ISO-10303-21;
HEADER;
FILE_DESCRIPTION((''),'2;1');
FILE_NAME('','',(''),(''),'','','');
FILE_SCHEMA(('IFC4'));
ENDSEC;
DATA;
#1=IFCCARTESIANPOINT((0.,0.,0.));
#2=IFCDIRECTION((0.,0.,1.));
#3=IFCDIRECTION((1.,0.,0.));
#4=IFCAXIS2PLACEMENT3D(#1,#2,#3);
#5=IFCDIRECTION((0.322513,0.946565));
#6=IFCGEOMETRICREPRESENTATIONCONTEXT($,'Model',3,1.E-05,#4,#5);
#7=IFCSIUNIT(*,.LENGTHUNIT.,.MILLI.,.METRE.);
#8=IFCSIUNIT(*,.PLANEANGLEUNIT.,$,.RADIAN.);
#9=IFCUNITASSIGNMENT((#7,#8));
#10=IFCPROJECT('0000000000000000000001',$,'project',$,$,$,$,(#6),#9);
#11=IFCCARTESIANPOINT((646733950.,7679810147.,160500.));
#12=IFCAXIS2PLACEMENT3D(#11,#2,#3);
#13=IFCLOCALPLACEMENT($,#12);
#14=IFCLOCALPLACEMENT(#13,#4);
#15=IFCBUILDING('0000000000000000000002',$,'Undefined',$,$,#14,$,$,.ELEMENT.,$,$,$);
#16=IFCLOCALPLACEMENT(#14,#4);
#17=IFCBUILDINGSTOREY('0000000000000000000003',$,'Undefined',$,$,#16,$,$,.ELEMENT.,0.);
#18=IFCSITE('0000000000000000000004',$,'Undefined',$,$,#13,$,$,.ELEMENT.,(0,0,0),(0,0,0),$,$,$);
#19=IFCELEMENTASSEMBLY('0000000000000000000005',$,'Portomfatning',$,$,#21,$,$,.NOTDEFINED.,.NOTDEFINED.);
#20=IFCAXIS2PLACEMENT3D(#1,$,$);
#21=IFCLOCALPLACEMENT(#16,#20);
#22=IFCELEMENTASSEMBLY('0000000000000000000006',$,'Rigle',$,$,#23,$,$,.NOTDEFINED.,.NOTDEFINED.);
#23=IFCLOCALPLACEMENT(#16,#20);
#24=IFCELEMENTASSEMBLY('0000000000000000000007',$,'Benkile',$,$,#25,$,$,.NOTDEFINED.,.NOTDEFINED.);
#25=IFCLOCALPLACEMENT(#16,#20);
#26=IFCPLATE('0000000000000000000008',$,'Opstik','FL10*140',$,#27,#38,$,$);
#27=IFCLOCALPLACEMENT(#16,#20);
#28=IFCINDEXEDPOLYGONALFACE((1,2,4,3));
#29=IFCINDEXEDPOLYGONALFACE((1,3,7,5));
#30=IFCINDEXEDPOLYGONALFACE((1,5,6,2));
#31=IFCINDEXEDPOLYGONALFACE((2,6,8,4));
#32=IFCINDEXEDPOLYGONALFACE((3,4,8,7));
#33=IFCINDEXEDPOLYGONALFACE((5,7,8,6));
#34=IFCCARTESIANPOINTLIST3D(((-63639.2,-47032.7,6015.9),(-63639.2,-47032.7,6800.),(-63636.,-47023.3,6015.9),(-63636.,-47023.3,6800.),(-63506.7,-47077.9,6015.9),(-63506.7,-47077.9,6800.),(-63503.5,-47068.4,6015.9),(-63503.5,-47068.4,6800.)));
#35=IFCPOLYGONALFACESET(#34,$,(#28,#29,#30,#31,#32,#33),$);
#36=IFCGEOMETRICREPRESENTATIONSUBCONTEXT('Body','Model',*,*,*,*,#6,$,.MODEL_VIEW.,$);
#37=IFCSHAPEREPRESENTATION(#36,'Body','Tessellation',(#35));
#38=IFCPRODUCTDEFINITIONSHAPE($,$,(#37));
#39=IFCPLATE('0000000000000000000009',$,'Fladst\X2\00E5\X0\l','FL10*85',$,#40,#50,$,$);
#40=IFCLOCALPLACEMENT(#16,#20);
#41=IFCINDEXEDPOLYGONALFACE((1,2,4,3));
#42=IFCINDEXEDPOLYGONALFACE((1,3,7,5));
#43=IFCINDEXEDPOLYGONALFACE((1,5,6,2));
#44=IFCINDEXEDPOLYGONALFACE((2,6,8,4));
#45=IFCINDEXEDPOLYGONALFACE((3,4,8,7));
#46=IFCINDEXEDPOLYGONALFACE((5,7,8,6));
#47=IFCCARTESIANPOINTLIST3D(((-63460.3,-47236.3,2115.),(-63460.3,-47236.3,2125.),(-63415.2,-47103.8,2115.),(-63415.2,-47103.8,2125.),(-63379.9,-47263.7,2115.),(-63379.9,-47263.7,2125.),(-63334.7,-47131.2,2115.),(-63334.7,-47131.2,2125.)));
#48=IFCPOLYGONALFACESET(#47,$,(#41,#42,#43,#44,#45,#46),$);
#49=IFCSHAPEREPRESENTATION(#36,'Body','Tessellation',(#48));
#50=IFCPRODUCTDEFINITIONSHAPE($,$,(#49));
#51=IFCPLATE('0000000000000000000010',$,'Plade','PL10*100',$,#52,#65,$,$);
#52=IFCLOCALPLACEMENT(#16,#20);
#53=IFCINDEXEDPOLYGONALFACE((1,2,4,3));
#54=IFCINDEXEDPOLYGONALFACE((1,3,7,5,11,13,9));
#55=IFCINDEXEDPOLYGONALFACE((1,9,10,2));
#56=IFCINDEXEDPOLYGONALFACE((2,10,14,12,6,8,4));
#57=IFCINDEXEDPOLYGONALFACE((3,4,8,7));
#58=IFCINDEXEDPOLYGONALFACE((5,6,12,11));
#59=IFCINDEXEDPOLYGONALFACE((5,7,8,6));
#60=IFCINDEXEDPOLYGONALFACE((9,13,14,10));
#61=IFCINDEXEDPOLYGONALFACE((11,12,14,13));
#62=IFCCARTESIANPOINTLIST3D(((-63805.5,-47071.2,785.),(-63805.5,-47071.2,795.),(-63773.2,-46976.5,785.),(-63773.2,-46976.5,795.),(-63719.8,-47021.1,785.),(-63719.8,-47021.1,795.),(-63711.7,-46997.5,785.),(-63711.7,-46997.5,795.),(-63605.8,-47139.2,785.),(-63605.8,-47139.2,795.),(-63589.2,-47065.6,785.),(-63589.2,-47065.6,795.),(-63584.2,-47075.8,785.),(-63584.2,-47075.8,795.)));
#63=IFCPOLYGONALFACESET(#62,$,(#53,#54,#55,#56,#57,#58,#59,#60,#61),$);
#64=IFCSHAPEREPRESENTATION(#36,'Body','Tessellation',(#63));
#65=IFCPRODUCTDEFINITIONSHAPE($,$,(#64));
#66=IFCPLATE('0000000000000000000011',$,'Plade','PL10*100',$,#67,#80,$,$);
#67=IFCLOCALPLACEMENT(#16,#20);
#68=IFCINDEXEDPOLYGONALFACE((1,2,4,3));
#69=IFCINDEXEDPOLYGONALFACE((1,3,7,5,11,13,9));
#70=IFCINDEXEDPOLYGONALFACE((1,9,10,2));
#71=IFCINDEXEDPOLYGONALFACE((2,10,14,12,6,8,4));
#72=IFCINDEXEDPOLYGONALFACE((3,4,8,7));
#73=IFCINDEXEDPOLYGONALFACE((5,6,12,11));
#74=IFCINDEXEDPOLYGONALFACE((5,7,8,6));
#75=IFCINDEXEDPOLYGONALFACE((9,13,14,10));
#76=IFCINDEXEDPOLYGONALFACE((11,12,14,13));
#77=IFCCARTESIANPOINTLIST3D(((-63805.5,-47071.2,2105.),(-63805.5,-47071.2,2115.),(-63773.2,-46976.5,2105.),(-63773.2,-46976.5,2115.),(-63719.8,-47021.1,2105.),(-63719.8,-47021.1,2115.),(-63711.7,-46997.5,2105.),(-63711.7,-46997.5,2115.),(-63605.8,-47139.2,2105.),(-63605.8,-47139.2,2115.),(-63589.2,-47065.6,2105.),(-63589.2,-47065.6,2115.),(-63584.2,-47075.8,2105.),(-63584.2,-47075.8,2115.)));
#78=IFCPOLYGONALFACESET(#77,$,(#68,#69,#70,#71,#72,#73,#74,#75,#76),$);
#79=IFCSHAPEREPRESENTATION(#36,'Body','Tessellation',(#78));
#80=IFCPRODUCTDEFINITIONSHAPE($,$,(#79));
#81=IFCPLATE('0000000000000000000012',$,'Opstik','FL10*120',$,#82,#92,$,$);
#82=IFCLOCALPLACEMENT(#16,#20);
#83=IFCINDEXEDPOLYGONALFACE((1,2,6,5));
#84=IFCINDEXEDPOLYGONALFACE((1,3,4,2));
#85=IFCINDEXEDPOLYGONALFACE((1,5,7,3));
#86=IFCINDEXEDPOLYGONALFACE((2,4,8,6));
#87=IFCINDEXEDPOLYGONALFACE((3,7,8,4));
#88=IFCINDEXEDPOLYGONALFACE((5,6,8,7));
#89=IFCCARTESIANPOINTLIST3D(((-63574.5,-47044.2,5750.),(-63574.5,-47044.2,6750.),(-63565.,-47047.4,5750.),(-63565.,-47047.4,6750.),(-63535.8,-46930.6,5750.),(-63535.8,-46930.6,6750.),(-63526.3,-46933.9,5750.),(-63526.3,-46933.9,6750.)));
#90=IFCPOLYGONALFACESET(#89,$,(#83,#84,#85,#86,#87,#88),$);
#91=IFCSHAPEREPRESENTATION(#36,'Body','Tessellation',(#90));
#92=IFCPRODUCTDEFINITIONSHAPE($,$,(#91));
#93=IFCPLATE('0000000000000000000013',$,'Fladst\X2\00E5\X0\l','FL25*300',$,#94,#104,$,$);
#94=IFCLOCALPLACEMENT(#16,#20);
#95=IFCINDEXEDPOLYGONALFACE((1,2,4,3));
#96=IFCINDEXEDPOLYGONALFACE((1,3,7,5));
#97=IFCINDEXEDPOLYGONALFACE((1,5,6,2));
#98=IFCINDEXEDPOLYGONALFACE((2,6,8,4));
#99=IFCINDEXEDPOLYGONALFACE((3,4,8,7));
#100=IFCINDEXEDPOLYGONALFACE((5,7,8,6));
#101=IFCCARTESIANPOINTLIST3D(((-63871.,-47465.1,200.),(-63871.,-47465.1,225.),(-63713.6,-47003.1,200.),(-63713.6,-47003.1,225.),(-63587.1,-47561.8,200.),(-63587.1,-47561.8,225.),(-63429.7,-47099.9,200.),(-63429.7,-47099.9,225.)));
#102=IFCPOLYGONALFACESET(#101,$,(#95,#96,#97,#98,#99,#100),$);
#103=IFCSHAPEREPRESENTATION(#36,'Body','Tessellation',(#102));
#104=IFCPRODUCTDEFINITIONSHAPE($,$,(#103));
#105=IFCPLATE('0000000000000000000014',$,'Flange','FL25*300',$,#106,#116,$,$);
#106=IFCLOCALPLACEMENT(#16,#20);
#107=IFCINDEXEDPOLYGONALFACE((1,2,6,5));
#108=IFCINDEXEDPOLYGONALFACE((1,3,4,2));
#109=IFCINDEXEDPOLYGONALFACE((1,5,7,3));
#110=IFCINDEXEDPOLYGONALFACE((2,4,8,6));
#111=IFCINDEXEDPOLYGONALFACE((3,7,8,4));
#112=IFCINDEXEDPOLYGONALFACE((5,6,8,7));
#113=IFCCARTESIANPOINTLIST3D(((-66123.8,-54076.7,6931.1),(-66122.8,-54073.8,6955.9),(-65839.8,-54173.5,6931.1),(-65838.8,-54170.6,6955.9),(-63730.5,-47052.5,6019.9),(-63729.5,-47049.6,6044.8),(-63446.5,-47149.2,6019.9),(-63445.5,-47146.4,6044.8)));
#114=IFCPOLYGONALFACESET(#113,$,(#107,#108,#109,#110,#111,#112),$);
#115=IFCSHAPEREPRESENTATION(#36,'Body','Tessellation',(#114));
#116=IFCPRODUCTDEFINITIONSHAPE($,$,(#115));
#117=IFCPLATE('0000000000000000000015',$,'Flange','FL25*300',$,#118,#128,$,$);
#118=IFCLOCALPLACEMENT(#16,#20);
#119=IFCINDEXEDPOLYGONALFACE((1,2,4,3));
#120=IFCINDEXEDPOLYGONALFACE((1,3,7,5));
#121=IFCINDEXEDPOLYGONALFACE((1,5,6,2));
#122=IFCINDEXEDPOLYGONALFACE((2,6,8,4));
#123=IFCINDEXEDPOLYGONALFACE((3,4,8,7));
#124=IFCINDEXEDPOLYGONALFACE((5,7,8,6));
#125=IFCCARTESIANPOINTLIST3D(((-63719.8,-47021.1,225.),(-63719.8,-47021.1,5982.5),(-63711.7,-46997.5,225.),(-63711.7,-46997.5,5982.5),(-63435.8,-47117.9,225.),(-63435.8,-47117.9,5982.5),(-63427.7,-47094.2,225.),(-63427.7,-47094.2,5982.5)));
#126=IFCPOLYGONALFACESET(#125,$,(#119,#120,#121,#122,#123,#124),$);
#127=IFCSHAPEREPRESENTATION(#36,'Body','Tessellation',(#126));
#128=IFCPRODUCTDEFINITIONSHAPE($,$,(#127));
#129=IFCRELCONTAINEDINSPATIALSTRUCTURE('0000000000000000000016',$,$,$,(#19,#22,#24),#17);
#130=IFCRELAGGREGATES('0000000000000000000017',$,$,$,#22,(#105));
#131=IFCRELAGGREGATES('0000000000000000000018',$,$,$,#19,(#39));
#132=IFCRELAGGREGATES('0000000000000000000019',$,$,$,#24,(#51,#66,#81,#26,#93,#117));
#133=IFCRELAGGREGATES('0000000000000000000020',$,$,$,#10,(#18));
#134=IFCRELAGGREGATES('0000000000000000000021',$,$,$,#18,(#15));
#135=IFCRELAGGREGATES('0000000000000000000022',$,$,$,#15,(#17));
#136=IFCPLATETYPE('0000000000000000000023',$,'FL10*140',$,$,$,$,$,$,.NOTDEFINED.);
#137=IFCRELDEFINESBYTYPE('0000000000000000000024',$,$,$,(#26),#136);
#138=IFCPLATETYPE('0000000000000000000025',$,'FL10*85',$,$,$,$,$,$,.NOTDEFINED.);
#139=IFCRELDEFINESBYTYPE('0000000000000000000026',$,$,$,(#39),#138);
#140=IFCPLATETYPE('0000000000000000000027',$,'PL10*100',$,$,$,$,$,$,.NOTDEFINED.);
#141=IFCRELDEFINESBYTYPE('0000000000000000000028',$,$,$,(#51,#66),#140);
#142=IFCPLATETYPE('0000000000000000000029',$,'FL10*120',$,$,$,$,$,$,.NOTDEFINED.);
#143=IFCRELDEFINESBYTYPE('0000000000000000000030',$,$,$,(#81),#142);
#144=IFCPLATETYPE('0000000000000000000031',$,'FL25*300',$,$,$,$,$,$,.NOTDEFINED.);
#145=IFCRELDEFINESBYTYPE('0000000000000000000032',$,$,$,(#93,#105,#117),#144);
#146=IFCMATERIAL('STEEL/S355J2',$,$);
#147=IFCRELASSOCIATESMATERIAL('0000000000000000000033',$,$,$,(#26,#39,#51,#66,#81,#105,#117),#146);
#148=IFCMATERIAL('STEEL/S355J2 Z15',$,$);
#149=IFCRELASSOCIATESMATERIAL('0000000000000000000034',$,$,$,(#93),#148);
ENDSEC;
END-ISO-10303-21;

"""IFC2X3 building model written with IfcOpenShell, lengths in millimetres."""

from ifc_helpers import new_model, si_unit, direction, frame, origin_with_axes, place, context, subcontext, project, spatial, polyline, outline, extrude, boolean, clip, halfspace, material, type_object, element, aggregate, save


model = new_model("IFC2X3")

# Units and contexts
model_context = context("Model", 3, precision=1e-05, world=origin_with_axes(), true_north=direction((0.322513, 0.946565)))
body_context = subcontext(model_context, "Body", "Model", "MODEL_VIEW")
ifc_project = project(units=[si_unit("LENGTHUNIT", "METRE", prefix="MILLI"), si_unit("PLANEANGLEUNIT", "RADIAN")], contexts=[model_context])

# Site, building, storey
site_placement = place(None, frame((646733950.0, 7679810147.0, 160500.0), z_axis=(0.0, 0.0, 1.0), x_axis=(1.0, 0.0, 0.0)))
site = spatial("IfcSite", under=ifc_project, at=site_placement, Name="Undefined", CompositionType="ELEMENT", RefLatitude=(0, 0, 0), RefLongitude=(0, 0, 0))
building_placement = place(site_placement, origin_with_axes())
building = spatial("IfcBuilding", under=site, at=building_placement, Name="Undefined", CompositionType="ELEMENT")
storey_placement = place(building_placement, origin_with_axes())
storey = spatial("IfcBuildingStorey", under=building, at=storey_placement, Name="Undefined", CompositionType="ELEMENT", Elevation=0.0)

# Element assembly
assembly_1_placement = place(storey_placement, origin_with_axes())
assembly_1 = element("IfcElementAssembly", 1, at=assembly_1_placement, inside=storey, Name="Portomfatning", AssemblyPlace="NOTDEFINED", PredefinedType="NOTDEFINED")
ifc_material_1 = material(Name="STEEL/S355J2")

# Element assembly
assembly_2_placement = place(storey_placement, origin_with_axes())
assembly_2 = element("IfcElementAssembly", 2, at=assembly_2_placement, inside=storey, Name="Rigle", AssemblyPlace="NOTDEFINED", PredefinedType="NOTDEFINED")

# Element assembly
assembly_3_placement = place(storey_placement, origin_with_axes())
assembly_3 = element("IfcElementAssembly", 3, at=assembly_3_placement, inside=storey, Name="Benkile", AssemblyPlace="NOTDEFINED", PredefinedType="NOTDEFINED")

# Plates
plate_type_1 = type_object("IfcPlateType", Name="FL10*140", PredefinedType="NOTDEFINED")
plate_1_placement = place(assembly_3_placement, frame((-63637.6, -47028.0, 6015.9), z_axis=(0.322513, 0.946565, 0.0), x_axis=(0.0, 0.0, 1.0)))
plate_1 = element("IfcPlate", 4, at=plate_1_placement, type_object=plate_type_1, material=ifc_material_1, Name="Opstik", Description="FL10*140", context=body_context, shape_type="SweptSolid", body=[
    extrude(outline(polyline([(0.0, 0.0), (784.1, 0.0), (784.1, 0.0), (784.1, 140.0), (784.1, 140.0), (0.0, 140.0), (0.0, 0.0)])), frame((0.0, 0.0, -5.0), z_axis=(0.0, 0.0, 1.0), x_axis=(1.0, 0.0, 0.0)), (0.0, 0.0, 1.0), 10.0),
])
plate_type_2 = type_object("IfcPlateType", Name="FL10*85", PredefinedType="NOTDEFINED")
plate_2_placement = place(assembly_1_placement, frame((-63357.3, -47197.5, 2120.0), z_axis=(0.0, 0.0, 1.0), x_axis=(-0.946565, 0.322513, 0.0)))
plate_2 = element("IfcPlate", 5, at=plate_2_placement, type_object=plate_type_2, material=ifc_material_1, Name="Fladstål", Description="FL10*85", context=body_context, shape_type="SweptSolid", body=[
    extrude(outline(polyline([(0.0, -70.0), (0.0, 70.0), (85.0, 70.0), (85.0, -70.0), (0.0, -70.0)])), frame((0.0, 0.0, -5.0), z_axis=(0.0, 0.0, 1.0), x_axis=(1.0, 0.0, 0.0)), (0.0, 0.0, 1.0), 10.0),
])
plate_type_3 = type_object("IfcPlateType", Name="PL10*100", PredefinedType="NOTDEFINED")
plate_3_placement = place(assembly_3_placement, frame((-63573.5, -47044.5, 790.0), z_axis=(0.0, 0.0, 1.0), x_axis=(-0.946565, 0.322513, 0.0)))
plate_3 = element("IfcPlate", 6, at=plate_3_placement, type_object=plate_type_3, material=ifc_material_1, Name="Plade", Description="PL10*100", context=body_context, shape_type="CSG", body=[
    boolean("DIFFERENCE", extrude(outline(polyline([(0.0, 25.0), (146.0, 25.0), (146.0, 0.0), (211.0, 0.0), (211.0, 100.0), (0.0, 100.0), (0.0, 25.0)])), frame((0.0, 0.0, -5.0), z_axis=(0.0, 0.0, 1.0), x_axis=(1.0, 0.0, 0.0)), (0.0, 0.0, 1.0), 10.0), extrude(outline(polyline([(0.0, 0.0), (8.0, 0.0), (0.0, 8.0), (0.0, 0.0)])), frame((0.0, 25.0, -7.5), z_axis=(0.0, 0.0, 1.0), x_axis=(1.0, 0.0, 0.0)), (0.0, 0.0, 1.0), 15.0)),
])
plate_4_placement = place(assembly_3_placement, frame((-63573.5, -47044.5, 2110.0), z_axis=(0.0, 0.0, 1.0), x_axis=(-0.946565, 0.322513, 0.0)))
plate_4 = element("IfcPlate", 7, at=plate_4_placement, type_object=plate_type_3, material=ifc_material_1, Name="Plade", Description="PL10*100", context=body_context, shape_type="CSG", body=[
    boolean("DIFFERENCE", extrude(outline(polyline([(0.0, 25.0), (146.0, 25.0), (146.0, 0.0), (211.0, 0.0), (211.0, 100.0), (0.0, 100.0), (0.0, 25.0)])), frame((0.0, 0.0, -5.0), z_axis=(0.0, 0.0, 1.0), x_axis=(1.0, 0.0, 0.0)), (0.0, 0.0, 1.0), 10.0), extrude(outline(polyline([(0.0, 0.0), (8.0, 0.0), (0.0, 8.0), (0.0, 0.0)])), frame((0.0, 25.0, -7.5), z_axis=(0.0, 0.0, 1.0), x_axis=(1.0, 0.0, 0.0)), (0.0, 0.0, 1.0), 15.0)),
])
plate_type_4 = type_object("IfcPlateType", Name="FL10*120", PredefinedType="NOTDEFINED")
plate_5_placement = place(assembly_3_placement, frame((-63569.7, -47045.8, 5750.0), z_axis=(-0.946565, 0.322513, 0.0), x_axis=(0.0, 0.0, 1.0)))
plate_5 = element("IfcPlate", 8, at=plate_5_placement, type_object=plate_type_4, material=ifc_material_1, Name="Opstik", Description="FL10*120", context=body_context, shape_type="SweptSolid", body=[
    extrude(outline(polyline([(0.0, 0.0), (1000.0, 0.0), (1000.0, 120.0), (1000.0, 120.0), (0.0, 120.0), (0.0, 120.0), (0.0, 0.0)])), frame((0.0, 0.0, -5.0), z_axis=(0.0, 0.0, 1.0), x_axis=(1.0, 0.0, 0.0)), (0.0, 0.0, 1.0), 10.0),
])
ifc_material_2 = material(Name="STEEL/S355J2 Z15")
plate_type_5 = type_object("IfcPlateType", Name="FL25*300", PredefinedType="NOTDEFINED")
plate_6_placement = place(assembly_3_placement, frame((-63571.7, -47051.5, 212.5), z_axis=(0.0, 0.0, -1.0), x_axis=(-0.322513, -0.946565, 0.0)))
plate_6 = element("IfcPlate", 9, at=plate_6_placement, type_object=plate_type_5, material=ifc_material_2, Name="Fladstål", Description="FL25*300", context=body_context, shape_type="SweptSolid", body=[
    extrude(outline(polyline([(0.0, -150.0), (0.0, 150.0), (488.0, 150.0), (488.0, -150.0), (0.0, -150.0)])), frame((0.0, 0.0, -12.5), z_axis=(0.0, 0.0, 1.0), x_axis=(1.0, 0.0, 0.0)), (0.0, 0.0, 1.0), 25.0),
])
plate_7_placement = place(assembly_2_placement, frame((-63588.0, -47099.4, 6032.4), z_axis=(-0.039304, -0.115357, -0.992546), x_axis=(-0.320109, -0.93951, 0.121869)))
plate_7 = element("IfcPlate", 10, at=plate_7_placement, type_object=plate_type_5, material=ifc_material_1, Name="Flange", Description="FL25*300", context=body_context, shape_type="Clipping", body=[
    clip(extrude(outline(polyline([(0.0, -150.0), (0.0, 150.0), (7476.5, 150.0), (7476.5, -150.0), (0.0, -150.0)])), frame((0.0, 0.0, -12.5), z_axis=(0.0, 0.0, 1.0), x_axis=(1.0, 0.0, 0.0)), (0.0, 0.0, 1.0), 25.0), halfspace(frame((7476.5, 0.0, 287.5), z_axis=(1.0, 0.0, 0.0), x_axis=(0.0, 1.0, 0.0)), False)),
])
aggregate(assembly_2, [plate_7])
plate_8_placement = place(assembly_3_placement, frame((-63573.8, -47057.7, 200.0), z_axis=(-0.322513, -0.946565, 0.0), x_axis=(0.0, 0.0, 1.0)))
plate_8 = element("IfcPlate", 11, at=plate_8_placement, type_object=plate_type_5, material=ifc_material_1, Name="Flange", Description="FL25*300", context=body_context, shape_type="Clipping", body=[
    clip(extrude(outline(polyline([(25.0, -150.0), (25.0, 150.0), (5782.5, 150.0), (5782.5, -150.0), (25.0, -150.0)])), frame((0.0, 0.0, -12.5), z_axis=(0.0, 0.0, 1.0), x_axis=(1.0, 0.0, 0.0)), (0.0, 0.0, 1.0), 25.0), halfspace(frame((25.0, 0.0, 12.5), z_axis=(-1.0, 0.0, 0.0), x_axis=(0.0, 1.0, 0.0)), False)),
])

aggregate(assembly_1, [plate_2])

aggregate(assembly_3, [plate_3, plate_4, plate_5, plate_1, plate_6, plate_8])

save(model, "model.ifc")
